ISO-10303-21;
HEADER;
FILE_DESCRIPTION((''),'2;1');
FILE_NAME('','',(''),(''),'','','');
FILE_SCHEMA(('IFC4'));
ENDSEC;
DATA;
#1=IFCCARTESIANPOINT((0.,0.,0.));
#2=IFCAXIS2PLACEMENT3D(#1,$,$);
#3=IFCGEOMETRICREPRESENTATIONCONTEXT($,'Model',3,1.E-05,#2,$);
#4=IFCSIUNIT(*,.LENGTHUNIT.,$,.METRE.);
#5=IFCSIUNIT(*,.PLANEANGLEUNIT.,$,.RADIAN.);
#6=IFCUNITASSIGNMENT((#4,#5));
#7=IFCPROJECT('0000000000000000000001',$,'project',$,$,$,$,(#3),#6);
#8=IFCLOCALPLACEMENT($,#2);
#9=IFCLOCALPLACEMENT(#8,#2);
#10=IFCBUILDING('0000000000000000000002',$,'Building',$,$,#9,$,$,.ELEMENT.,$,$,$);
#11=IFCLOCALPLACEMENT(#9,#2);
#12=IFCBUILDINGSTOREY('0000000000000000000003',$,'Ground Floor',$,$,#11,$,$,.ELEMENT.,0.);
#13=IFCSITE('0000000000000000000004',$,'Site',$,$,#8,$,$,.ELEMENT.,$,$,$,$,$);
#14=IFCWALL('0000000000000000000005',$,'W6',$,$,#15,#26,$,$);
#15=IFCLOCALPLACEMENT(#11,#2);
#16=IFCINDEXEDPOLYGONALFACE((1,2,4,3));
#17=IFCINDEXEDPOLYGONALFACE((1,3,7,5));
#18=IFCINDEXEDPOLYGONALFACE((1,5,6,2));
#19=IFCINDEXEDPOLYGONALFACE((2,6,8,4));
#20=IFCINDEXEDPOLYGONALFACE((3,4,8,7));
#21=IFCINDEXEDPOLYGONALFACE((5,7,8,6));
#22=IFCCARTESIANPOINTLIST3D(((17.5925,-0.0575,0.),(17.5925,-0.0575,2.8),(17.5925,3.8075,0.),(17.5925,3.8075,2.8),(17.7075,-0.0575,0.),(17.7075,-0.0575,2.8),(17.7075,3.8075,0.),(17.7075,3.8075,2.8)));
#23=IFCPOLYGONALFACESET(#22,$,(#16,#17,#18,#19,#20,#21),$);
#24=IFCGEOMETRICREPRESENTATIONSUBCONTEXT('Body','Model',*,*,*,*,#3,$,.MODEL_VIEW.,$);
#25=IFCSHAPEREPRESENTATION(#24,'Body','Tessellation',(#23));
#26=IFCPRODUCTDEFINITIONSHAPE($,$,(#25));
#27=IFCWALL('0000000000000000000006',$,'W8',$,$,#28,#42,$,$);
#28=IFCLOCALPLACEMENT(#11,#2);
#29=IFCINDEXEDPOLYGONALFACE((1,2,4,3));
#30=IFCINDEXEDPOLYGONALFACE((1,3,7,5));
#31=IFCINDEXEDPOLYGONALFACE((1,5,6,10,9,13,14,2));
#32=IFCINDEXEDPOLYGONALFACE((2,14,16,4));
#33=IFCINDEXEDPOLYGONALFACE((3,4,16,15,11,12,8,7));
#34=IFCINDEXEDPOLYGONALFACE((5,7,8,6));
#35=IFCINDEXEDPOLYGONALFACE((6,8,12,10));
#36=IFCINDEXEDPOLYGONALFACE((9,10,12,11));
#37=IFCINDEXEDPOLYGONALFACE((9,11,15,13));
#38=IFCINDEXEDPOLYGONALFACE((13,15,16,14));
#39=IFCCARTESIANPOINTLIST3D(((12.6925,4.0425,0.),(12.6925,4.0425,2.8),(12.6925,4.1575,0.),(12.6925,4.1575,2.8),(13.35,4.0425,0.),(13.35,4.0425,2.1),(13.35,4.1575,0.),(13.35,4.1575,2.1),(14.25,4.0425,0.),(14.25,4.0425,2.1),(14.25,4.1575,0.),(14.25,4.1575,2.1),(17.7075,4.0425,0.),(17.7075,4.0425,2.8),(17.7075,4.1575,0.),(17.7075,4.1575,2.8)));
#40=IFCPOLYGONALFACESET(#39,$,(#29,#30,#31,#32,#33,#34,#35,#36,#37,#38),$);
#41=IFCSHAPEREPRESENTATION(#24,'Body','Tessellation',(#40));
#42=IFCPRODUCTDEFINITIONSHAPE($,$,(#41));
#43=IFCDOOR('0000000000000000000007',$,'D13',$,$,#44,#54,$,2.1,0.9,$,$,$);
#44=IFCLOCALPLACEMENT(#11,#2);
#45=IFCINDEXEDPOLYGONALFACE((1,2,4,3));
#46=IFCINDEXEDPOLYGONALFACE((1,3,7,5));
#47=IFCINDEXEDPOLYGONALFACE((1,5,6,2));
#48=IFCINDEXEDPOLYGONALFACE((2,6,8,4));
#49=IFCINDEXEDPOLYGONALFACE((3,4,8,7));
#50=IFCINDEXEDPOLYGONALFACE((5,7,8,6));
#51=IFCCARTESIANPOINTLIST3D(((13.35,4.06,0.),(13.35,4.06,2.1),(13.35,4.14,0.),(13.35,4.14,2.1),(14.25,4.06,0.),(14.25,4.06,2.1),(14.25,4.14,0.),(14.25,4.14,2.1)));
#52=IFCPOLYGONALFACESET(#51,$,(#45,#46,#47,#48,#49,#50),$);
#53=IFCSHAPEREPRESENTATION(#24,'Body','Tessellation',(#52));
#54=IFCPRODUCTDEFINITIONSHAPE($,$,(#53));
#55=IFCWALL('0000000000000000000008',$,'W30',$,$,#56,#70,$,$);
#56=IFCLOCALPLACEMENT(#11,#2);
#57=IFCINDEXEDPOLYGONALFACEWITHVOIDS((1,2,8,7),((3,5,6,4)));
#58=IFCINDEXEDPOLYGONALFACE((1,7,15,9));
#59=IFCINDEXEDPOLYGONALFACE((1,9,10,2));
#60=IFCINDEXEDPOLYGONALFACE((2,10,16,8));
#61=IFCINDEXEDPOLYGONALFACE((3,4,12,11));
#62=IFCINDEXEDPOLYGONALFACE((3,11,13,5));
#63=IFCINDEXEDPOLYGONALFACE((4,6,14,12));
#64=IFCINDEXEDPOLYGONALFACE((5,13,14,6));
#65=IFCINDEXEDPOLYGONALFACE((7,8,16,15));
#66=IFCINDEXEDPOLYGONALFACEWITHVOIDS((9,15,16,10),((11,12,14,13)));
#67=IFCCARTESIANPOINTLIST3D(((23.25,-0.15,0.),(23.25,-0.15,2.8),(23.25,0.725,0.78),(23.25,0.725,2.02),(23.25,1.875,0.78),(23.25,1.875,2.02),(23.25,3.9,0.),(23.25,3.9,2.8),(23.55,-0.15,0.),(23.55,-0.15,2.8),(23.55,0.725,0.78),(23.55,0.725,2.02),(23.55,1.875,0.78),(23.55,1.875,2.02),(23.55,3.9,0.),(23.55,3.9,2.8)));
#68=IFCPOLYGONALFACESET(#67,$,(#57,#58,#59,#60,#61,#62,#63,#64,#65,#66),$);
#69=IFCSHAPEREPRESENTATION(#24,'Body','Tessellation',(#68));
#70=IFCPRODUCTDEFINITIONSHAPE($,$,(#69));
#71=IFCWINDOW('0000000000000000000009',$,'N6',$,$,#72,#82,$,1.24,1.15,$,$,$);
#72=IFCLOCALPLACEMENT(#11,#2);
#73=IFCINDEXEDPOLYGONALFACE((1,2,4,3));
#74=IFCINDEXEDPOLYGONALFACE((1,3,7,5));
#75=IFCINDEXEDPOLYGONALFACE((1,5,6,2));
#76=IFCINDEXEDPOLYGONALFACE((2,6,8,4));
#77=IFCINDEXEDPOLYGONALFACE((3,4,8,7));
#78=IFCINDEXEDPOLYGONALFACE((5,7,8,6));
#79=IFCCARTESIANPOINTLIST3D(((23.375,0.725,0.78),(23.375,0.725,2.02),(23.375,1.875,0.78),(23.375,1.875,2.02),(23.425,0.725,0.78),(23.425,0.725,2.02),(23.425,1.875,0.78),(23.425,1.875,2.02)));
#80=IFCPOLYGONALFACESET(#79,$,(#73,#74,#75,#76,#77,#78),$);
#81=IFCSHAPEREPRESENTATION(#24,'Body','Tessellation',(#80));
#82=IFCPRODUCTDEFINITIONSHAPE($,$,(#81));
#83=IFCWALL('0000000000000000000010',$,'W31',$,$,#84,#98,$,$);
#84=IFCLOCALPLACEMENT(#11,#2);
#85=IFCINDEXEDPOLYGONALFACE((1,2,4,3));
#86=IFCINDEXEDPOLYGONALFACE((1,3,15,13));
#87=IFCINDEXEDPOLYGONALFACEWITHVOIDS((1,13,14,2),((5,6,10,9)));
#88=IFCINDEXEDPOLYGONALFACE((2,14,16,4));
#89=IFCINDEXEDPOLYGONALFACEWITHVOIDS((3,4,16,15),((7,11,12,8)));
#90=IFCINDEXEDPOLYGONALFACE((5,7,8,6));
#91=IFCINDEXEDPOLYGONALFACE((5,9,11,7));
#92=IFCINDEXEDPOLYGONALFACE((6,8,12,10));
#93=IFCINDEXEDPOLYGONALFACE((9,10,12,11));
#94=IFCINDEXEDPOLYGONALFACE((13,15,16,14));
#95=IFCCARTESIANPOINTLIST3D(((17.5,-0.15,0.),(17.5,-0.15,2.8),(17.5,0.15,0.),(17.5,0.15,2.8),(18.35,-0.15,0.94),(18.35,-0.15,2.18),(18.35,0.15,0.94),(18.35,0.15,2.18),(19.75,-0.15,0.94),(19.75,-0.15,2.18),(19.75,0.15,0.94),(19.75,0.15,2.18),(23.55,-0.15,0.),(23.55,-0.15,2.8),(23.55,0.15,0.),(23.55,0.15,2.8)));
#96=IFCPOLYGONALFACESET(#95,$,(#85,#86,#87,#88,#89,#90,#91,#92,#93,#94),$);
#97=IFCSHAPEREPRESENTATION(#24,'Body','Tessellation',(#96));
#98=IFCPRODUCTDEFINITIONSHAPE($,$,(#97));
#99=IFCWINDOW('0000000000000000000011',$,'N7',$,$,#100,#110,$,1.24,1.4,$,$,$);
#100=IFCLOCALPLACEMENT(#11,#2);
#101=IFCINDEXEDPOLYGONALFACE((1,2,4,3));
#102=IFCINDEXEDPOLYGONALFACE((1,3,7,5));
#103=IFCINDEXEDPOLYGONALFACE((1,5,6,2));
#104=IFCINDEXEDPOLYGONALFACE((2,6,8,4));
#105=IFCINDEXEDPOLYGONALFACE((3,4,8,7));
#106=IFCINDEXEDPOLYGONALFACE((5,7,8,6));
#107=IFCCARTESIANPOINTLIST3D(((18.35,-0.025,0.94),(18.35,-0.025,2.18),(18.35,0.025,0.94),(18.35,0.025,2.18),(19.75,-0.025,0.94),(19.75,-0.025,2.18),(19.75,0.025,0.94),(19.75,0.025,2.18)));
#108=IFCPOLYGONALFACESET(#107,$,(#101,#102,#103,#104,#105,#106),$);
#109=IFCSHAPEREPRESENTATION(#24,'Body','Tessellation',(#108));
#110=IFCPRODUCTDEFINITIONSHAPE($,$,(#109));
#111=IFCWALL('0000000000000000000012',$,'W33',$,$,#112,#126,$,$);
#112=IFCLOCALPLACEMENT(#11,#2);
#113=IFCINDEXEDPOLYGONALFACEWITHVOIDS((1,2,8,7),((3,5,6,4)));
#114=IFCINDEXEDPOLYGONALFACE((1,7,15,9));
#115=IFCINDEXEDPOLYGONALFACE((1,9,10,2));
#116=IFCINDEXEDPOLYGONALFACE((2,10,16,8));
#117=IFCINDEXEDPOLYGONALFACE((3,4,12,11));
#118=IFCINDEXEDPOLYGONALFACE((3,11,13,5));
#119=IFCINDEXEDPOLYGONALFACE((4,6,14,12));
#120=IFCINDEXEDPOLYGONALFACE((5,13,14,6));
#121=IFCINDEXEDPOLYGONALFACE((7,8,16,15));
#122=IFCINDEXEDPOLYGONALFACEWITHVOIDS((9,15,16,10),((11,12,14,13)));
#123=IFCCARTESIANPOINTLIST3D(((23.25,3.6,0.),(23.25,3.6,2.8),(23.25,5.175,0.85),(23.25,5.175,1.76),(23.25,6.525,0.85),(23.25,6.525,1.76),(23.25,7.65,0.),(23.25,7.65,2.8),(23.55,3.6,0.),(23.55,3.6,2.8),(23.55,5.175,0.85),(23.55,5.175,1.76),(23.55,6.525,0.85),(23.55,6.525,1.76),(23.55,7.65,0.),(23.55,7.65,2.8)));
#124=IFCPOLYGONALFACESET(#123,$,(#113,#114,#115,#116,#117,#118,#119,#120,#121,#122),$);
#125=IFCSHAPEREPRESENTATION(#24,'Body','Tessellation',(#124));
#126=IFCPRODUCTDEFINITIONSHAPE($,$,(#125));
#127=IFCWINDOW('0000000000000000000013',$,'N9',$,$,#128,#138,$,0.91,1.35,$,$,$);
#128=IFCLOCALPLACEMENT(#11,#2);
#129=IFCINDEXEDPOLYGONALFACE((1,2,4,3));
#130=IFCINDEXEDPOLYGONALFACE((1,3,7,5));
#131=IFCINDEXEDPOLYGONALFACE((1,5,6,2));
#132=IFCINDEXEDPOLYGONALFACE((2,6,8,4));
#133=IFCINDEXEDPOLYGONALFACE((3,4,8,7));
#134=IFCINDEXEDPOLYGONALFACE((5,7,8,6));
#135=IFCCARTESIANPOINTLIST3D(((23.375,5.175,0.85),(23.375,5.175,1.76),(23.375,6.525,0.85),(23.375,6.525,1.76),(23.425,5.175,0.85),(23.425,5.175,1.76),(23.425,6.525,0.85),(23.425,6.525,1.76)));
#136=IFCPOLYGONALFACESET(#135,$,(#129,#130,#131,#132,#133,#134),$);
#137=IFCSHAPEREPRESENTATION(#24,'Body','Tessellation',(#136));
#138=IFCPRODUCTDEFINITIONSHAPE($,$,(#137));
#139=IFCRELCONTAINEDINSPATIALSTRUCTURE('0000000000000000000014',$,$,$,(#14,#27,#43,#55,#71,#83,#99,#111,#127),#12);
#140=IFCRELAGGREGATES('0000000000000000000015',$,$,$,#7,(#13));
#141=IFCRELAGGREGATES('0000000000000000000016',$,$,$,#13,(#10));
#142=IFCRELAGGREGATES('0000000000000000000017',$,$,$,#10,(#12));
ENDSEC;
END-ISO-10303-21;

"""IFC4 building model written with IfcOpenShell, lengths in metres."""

from ifc_helpers import new_model, si_unit, frame, frame_2d, origin, origin_2d, place, context, subcontext, project, spatial, rectangle, extrude, element, fill, save


model = new_model("IFC4")

# Units and contexts
model_context = context("Model", 3, precision=1e-05, world=origin())
body_context = subcontext(model_context, "Body", "Model", "MODEL_VIEW")
ifc_project = project(units=[si_unit("LENGTHUNIT", "METRE"), si_unit("PLANEANGLEUNIT", "RADIAN")], contexts=[model_context])

# Site, building, storey
site_placement = place(None, origin())
site = spatial("IfcSite", under=ifc_project, at=site_placement, Name="Site", CompositionType="ELEMENT")
building_placement = place(site_placement, origin())
building = spatial("IfcBuilding", under=site, at=building_placement, Name="Building", CompositionType="ELEMENT")
storey_placement = place(building_placement, origin())
storey = spatial("IfcBuildingStorey", under=building, at=storey_placement, Name="Ground Floor", CompositionType="ELEMENT", Elevation=0.0)

# Wall
wall_1_placement = place(storey_placement, frame((17.65, 0.0, 0.0), x_axis=(0.0, 1.0, 0.0)))
element("IfcWall", 1, at=wall_1_placement, inside=storey, Name="W6", context=body_context, shape_type="SweptSolid", body=[
    extrude(rectangle(XDim=3.865, YDim=0.115, at=frame_2d((1.875, 0.0))), origin(), (0.0, 0.0, 1.0), 2.8),
])

# Wall, opening, door
wall_2_placement = place(storey_placement, frame((12.75, 4.1, 0.0), x_axis=(1.0, 0.0, 0.0)))
wall_2 = element("IfcWall", 2, at=wall_2_placement, inside=storey, Name="W8", context=body_context, shape_type="SweptSolid", body=[
    extrude(rectangle(XDim=5.015, YDim=0.115, at=frame_2d((2.45, 0.0))), origin(), (0.0, 0.0, 1.0), 2.8),
])
opening_1_placement = place(wall_2_placement, frame((1.05, 0.0, 0.0)))
opening_1 = element("IfcOpeningElement", 3, at=opening_1_placement, cuts=wall_2, context=body_context, shape_type="SweptSolid", body=[
    extrude(rectangle(XDim=0.9, YDim=0.215, at=origin_2d()), origin(), (0.0, 0.0, 1.0), 2.1),
])
door_1_placement = place(opening_1_placement, origin())
door_1 = element("IfcDoor", 4, at=door_1_placement, inside=storey, Name="D13", OverallHeight=2.1, OverallWidth=0.9, context=body_context, shape_type="SweptSolid", body=[
    extrude(rectangle(XDim=0.9, YDim=0.08, at=origin_2d()), origin(), (0.0, 0.0, 1.0), 2.1),
])
fill(opening_1, door_1)

# Walls, openings, windows
wall_3_placement = place(storey_placement, frame((23.4, 0.0, 0.0), x_axis=(0.0, 1.0, 0.0)))
wall_3 = element("IfcWall", 5, at=wall_3_placement, inside=storey, Name="W30", context=body_context, shape_type="SweptSolid", body=[
    extrude(rectangle(XDim=4.05, YDim=0.3, at=frame_2d((1.875, 0.0))), origin(), (0.0, 0.0, 1.0), 2.8),
])
opening_2_placement = place(wall_3_placement, frame((1.3, 0.0, 0.78)))
opening_2 = element("IfcOpeningElement", 6, at=opening_2_placement, cuts=wall_3, context=body_context, shape_type="SweptSolid", body=[
    extrude(rectangle(XDim=1.15, YDim=0.4, at=origin_2d()), origin(), (0.0, 0.0, 1.0), 1.24),
])
window_1_placement = place(opening_2_placement, origin())
window_1 = element("IfcWindow", 7, at=window_1_placement, inside=storey, Name="N6", OverallHeight=1.24, OverallWidth=1.15, context=body_context, shape_type="SweptSolid", body=[
    extrude(rectangle(XDim=1.15, YDim=0.05, at=origin_2d()), origin(), (0.0, 0.0, 1.0), 1.24),
])
fill(opening_2, window_1)
wall_4_placement = place(storey_placement, frame((17.65, 0.0, 0.0), x_axis=(1.0, 0.0, 0.0)))
wall_4 = element("IfcWall", 8, at=wall_4_placement, inside=storey, Name="W31", context=body_context, shape_type="SweptSolid", body=[
    extrude(rectangle(XDim=6.05, YDim=0.3, at=frame_2d((2.875, 0.0))), origin(), (0.0, 0.0, 1.0), 2.8),
])
opening_3_placement = place(wall_4_placement, frame((1.4, 0.0, 0.94)))
opening_3 = element("IfcOpeningElement", 9, at=opening_3_placement, cuts=wall_4, context=body_context, shape_type="SweptSolid", body=[
    extrude(rectangle(XDim=1.4, YDim=0.4, at=origin_2d()), origin(), (0.0, 0.0, 1.0), 1.24),
])
window_2_placement = place(opening_3_placement, origin())
window_2 = element("IfcWindow", 10, at=window_2_placement, inside=storey, Name="N7", OverallHeight=1.24, OverallWidth=1.4, context=body_context, shape_type="SweptSolid", body=[
    extrude(rectangle(XDim=1.4, YDim=0.05, at=origin_2d()), origin(), (0.0, 0.0, 1.0), 1.24),
])
fill(opening_3, window_2)
wall_5_placement = place(storey_placement, frame((23.4, 3.75, 0.0), x_axis=(0.0, 1.0, 0.0)))
wall_5 = element("IfcWall", 11, at=wall_5_placement, inside=storey, Name="W33", context=body_context, shape_type="SweptSolid", body=[
    extrude(rectangle(XDim=4.05, YDim=0.3, at=frame_2d((1.875, 0.0))), origin(), (0.0, 0.0, 1.0), 2.8),
])
opening_4_placement = place(wall_5_placement, frame((2.1, 0.0, 0.85)))
opening_4 = element("IfcOpeningElement", 12, at=opening_4_placement, cuts=wall_5, context=body_context, shape_type="SweptSolid", body=[
    extrude(rectangle(XDim=1.35, YDim=0.4, at=origin_2d()), origin(), (0.0, 0.0, 1.0), 0.91),
])
window_3_placement = place(opening_4_placement, origin())
window_3 = element("IfcWindow", 13, at=window_3_placement, inside=storey, Name="N9", OverallHeight=0.91, OverallWidth=1.35, context=body_context, shape_type="SweptSolid", body=[
    extrude(rectangle(XDim=1.35, YDim=0.05, at=origin_2d()), origin(), (0.0, 0.0, 1.0), 0.91),
])
fill(opening_4, window_3)

save(model, "model.ifc")
